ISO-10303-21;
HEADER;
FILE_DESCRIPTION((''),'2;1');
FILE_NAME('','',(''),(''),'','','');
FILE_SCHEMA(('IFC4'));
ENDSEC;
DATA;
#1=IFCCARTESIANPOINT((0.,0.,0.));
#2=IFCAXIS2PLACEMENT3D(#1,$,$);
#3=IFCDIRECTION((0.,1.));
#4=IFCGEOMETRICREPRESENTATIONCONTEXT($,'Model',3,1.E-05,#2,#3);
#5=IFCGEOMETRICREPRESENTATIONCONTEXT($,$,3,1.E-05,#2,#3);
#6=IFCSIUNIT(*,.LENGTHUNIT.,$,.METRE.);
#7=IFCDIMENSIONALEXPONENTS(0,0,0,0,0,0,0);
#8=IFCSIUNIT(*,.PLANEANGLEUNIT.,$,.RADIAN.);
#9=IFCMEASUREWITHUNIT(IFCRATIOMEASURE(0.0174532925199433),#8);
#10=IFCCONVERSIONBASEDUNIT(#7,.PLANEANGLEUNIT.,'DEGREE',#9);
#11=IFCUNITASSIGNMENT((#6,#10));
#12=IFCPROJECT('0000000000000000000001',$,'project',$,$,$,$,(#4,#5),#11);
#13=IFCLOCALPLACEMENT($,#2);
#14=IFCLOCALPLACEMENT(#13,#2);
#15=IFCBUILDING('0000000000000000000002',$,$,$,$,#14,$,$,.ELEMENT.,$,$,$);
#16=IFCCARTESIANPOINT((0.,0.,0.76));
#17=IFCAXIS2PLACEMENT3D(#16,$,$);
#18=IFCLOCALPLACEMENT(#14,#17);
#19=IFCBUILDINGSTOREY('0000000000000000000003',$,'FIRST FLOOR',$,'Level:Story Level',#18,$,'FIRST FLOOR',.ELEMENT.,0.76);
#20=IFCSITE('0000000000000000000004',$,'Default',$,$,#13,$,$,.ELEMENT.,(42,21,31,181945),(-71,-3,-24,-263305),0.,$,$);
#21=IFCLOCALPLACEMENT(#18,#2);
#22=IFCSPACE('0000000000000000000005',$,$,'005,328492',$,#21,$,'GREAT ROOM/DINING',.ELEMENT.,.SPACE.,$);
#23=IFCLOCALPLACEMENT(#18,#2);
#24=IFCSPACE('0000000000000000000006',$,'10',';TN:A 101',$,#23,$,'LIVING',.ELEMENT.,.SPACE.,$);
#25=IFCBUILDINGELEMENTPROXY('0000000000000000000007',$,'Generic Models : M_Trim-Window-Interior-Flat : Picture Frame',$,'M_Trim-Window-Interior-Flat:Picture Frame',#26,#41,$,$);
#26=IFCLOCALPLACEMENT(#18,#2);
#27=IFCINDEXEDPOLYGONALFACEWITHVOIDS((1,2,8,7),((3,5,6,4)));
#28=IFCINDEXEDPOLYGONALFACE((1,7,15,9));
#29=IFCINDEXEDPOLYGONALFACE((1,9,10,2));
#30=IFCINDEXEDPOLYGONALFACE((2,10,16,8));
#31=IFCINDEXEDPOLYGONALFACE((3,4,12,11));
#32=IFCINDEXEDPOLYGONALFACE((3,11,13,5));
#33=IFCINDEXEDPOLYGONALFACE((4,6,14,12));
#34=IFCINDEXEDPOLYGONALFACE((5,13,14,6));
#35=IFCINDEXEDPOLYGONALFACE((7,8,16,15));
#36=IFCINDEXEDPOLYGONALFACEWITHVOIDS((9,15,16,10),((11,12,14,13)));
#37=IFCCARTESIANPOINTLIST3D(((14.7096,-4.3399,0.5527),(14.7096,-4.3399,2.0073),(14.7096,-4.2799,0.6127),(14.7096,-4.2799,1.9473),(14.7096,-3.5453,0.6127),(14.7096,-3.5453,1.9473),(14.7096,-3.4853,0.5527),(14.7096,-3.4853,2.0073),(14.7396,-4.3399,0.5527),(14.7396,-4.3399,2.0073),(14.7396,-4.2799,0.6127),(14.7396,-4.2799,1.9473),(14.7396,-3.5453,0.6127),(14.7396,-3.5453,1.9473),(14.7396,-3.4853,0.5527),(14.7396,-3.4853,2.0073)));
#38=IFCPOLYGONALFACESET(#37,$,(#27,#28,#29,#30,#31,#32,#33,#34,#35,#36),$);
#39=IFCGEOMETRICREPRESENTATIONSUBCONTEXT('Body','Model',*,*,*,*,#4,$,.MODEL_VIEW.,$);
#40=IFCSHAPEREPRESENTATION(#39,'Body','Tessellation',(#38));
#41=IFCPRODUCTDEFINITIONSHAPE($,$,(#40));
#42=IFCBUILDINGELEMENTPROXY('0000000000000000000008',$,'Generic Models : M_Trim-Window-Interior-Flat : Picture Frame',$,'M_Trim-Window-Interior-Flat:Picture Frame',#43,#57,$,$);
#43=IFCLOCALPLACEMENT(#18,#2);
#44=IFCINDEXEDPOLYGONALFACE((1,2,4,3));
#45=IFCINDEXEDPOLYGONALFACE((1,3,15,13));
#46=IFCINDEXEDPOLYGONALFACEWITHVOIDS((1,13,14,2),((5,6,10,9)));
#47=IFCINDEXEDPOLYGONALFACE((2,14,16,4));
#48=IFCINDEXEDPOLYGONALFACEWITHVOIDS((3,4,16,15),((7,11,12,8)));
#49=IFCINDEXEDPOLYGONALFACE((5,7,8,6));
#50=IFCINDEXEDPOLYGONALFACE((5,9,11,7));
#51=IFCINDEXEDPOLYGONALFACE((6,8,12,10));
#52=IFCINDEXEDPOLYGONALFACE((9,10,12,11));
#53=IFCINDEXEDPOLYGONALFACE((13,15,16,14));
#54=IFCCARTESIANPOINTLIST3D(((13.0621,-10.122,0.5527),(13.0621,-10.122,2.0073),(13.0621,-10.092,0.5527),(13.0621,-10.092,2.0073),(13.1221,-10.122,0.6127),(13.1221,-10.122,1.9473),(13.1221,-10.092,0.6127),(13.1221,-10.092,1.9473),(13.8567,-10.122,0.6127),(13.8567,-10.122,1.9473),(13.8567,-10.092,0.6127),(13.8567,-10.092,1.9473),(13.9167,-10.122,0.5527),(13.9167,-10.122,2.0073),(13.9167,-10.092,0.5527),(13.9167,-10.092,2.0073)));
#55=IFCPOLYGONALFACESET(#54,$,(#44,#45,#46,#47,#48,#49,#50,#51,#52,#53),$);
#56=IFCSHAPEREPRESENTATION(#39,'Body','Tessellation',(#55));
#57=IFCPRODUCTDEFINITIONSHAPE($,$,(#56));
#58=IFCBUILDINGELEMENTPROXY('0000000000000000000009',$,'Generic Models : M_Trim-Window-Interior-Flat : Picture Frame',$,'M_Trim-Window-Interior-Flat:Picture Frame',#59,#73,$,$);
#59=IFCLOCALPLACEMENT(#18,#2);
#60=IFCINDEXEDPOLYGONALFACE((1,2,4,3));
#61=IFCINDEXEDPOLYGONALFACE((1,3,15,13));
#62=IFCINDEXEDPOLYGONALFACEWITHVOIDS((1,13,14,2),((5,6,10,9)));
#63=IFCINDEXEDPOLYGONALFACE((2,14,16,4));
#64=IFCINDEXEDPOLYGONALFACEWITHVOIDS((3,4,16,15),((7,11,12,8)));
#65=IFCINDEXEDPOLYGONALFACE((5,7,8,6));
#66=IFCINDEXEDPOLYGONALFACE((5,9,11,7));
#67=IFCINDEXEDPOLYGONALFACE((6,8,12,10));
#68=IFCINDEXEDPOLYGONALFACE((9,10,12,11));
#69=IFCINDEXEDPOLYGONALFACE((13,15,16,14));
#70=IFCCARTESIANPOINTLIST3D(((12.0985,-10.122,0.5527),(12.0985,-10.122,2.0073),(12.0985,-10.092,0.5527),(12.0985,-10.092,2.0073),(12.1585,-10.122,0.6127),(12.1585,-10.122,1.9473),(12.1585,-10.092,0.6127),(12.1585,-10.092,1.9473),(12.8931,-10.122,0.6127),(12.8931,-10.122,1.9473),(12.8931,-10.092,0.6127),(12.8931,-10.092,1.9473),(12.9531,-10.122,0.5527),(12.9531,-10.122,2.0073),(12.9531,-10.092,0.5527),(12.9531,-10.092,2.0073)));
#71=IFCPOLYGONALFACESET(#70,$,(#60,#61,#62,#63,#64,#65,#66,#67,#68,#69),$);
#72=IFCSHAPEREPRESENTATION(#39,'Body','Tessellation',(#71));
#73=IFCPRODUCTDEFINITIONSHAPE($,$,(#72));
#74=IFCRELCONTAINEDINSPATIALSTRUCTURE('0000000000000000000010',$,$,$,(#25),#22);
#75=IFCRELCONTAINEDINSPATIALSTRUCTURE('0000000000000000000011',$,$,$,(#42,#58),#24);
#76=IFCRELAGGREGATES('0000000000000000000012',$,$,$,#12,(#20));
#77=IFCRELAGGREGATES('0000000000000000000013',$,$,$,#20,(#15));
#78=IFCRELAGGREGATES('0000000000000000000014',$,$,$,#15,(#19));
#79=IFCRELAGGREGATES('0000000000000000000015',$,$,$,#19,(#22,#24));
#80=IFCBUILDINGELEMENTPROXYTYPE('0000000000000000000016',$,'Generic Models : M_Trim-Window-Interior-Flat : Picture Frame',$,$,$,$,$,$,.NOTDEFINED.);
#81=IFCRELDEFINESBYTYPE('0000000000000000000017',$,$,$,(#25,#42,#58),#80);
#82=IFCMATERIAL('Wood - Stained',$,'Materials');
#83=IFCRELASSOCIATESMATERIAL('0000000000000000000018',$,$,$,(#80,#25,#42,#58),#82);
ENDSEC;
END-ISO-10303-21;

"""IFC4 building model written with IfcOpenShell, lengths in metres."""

from ifc_helpers import new_model, entity, si_unit, converted_unit, direction, frame, origin, place, context, subcontext, project, spatial, polyline, outline, extrude, source, transform, mapped, material, type_object, type_shapes, element, save


model = new_model("IFC4")

# Units and contexts
model_context = context("Model", 3, precision=1e-05, world=origin(), true_north=direction((0.0, 1.0)))
context_of_model = context(None, 3, precision=1e-05, world=origin(), true_north=direction((0.0, 1.0)))
body_context = subcontext(model_context, "Body", "Model", "MODEL_VIEW")
ifc_project = project(units=[si_unit("LENGTHUNIT", "METRE"), converted_unit("PLANEANGLEUNIT", "DEGREE", entity("IfcRatioMeasure", 0.0174532925199433), si_unit("PLANEANGLEUNIT", "RADIAN"), dimensions=[0, 0, 0, 0, 0, 0, 0])], contexts=[model_context, context_of_model])

# Site, building, storey
site_placement = place(None, origin())
site = spatial("IfcSite", under=ifc_project, at=site_placement, Name="Default", CompositionType="ELEMENT", RefLatitude=(42, 21, 31, 181945), RefLongitude=(-71, -3, -24, -263305), RefElevation=0.0)
building_placement = place(site_placement, origin())
building = spatial("IfcBuilding", under=site, at=building_placement, CompositionType="ELEMENT")
storey_placement = place(building_placement, frame((0.0, 0.0, 0.76)))
storey = spatial("IfcBuildingStorey", under=building, at=storey_placement, Name="FIRST FLOOR", ObjectType="Level:Story Level", LongName="FIRST FLOOR", CompositionType="ELEMENT", Elevation=0.76)

# Shared definitions
ifc_material_1 = material(Name="Wood - Stained", Category="Materials")

# Shared definitions
space_1_placement = place(storey_placement, origin())
space_1 = spatial("IfcSpace", under=storey, at=space_1_placement, Description="005,328492", LongName="GREAT ROOM/DINING", CompositionType="ELEMENT", PredefinedType="SPACE")

# Building element proxy
building_element_proxy_type_1 = type_object("IfcBuildingElementProxyType", Name="Generic Models : M_Trim-Window-Interior-Flat : Picture Frame", PredefinedType="NOTDEFINED", material=ifc_material_1)
shared_shape_1 = source(origin(), body_context, "Body", "SweptSolid", [
    extrude(outline(polyline([(-0.4273, -0.7273), (0.4273, -0.7273), (0.4273, 0.7273), (-0.4273, 0.7273), (-0.4273, -0.7273)]), holes=[polyline([(-0.3673, -0.6673), (-0.3673, 0.6673), (0.3673, 0.6673), (0.3673, -0.6673), (-0.3673, -0.6673)])]), frame((0.0, -0.68, 0.0), z_axis=(0.0, 0.0, 1.0), x_axis=(-1.0, 0.0, 0.0)), (0.0, 0.0, 1.0), 0.03),
])
type_shapes(building_element_proxy_type_1, [shared_shape_1])
proxy_1_placement = place(space_1_placement, frame((14.7396, -3.9126, 1.96), z_axis=(-1.0, 0.0, 0.0), x_axis=(0.0, -1.0, 0.0)))
element("IfcBuildingElementProxy", 1, at=proxy_1_placement, inside=space_1, type_object=building_element_proxy_type_1, material=ifc_material_1, Name="Generic Models : M_Trim-Window-Interior-Flat : Picture Frame", ObjectType="M_Trim-Window-Interior-Flat:Picture Frame", context=body_context, shape_type="MappedRepresentation", body=[
    mapped(shared_shape_1, transform((0.0, 0.0, 0.0), scale=1.0)),
])

# Shared definitions
space_2_placement = place(storey_placement, origin())
space_2 = spatial("IfcSpace", under=storey, at=space_2_placement, Name="10", Description=";TN:A 101", LongName="LIVING", CompositionType="ELEMENT", PredefinedType="SPACE")

# Building element proxies
for number, where, z_axis, x_axis, name in (
    (2, (13.4894, -10.122, 1.96), (0.0, 1.0, 0.0), (-1.0, 0.0, 0.0), "Generic Models : M_Trim-Window-Interior-Flat : Picture Frame"),
    (3, (12.5258, -10.122, 1.96), (0.0, 1.0, 0.0), (-1.0, 0.0, 0.0), "Generic Models : M_Trim-Window-Interior-Flat : Picture Frame"),
):
    element("IfcBuildingElementProxy", number, at=place(space_2_placement, frame(where, z_axis=z_axis, x_axis=x_axis)), inside=space_2, type_object=building_element_proxy_type_1, material=ifc_material_1, Name=name, ObjectType="M_Trim-Window-Interior-Flat:Picture Frame", context=body_context, shape_type="MappedRepresentation", body=[
        mapped(shared_shape_1, transform((0.0, 0.0, 0.0), scale=1.0)),
    ])

save(model, "model.ifc")
